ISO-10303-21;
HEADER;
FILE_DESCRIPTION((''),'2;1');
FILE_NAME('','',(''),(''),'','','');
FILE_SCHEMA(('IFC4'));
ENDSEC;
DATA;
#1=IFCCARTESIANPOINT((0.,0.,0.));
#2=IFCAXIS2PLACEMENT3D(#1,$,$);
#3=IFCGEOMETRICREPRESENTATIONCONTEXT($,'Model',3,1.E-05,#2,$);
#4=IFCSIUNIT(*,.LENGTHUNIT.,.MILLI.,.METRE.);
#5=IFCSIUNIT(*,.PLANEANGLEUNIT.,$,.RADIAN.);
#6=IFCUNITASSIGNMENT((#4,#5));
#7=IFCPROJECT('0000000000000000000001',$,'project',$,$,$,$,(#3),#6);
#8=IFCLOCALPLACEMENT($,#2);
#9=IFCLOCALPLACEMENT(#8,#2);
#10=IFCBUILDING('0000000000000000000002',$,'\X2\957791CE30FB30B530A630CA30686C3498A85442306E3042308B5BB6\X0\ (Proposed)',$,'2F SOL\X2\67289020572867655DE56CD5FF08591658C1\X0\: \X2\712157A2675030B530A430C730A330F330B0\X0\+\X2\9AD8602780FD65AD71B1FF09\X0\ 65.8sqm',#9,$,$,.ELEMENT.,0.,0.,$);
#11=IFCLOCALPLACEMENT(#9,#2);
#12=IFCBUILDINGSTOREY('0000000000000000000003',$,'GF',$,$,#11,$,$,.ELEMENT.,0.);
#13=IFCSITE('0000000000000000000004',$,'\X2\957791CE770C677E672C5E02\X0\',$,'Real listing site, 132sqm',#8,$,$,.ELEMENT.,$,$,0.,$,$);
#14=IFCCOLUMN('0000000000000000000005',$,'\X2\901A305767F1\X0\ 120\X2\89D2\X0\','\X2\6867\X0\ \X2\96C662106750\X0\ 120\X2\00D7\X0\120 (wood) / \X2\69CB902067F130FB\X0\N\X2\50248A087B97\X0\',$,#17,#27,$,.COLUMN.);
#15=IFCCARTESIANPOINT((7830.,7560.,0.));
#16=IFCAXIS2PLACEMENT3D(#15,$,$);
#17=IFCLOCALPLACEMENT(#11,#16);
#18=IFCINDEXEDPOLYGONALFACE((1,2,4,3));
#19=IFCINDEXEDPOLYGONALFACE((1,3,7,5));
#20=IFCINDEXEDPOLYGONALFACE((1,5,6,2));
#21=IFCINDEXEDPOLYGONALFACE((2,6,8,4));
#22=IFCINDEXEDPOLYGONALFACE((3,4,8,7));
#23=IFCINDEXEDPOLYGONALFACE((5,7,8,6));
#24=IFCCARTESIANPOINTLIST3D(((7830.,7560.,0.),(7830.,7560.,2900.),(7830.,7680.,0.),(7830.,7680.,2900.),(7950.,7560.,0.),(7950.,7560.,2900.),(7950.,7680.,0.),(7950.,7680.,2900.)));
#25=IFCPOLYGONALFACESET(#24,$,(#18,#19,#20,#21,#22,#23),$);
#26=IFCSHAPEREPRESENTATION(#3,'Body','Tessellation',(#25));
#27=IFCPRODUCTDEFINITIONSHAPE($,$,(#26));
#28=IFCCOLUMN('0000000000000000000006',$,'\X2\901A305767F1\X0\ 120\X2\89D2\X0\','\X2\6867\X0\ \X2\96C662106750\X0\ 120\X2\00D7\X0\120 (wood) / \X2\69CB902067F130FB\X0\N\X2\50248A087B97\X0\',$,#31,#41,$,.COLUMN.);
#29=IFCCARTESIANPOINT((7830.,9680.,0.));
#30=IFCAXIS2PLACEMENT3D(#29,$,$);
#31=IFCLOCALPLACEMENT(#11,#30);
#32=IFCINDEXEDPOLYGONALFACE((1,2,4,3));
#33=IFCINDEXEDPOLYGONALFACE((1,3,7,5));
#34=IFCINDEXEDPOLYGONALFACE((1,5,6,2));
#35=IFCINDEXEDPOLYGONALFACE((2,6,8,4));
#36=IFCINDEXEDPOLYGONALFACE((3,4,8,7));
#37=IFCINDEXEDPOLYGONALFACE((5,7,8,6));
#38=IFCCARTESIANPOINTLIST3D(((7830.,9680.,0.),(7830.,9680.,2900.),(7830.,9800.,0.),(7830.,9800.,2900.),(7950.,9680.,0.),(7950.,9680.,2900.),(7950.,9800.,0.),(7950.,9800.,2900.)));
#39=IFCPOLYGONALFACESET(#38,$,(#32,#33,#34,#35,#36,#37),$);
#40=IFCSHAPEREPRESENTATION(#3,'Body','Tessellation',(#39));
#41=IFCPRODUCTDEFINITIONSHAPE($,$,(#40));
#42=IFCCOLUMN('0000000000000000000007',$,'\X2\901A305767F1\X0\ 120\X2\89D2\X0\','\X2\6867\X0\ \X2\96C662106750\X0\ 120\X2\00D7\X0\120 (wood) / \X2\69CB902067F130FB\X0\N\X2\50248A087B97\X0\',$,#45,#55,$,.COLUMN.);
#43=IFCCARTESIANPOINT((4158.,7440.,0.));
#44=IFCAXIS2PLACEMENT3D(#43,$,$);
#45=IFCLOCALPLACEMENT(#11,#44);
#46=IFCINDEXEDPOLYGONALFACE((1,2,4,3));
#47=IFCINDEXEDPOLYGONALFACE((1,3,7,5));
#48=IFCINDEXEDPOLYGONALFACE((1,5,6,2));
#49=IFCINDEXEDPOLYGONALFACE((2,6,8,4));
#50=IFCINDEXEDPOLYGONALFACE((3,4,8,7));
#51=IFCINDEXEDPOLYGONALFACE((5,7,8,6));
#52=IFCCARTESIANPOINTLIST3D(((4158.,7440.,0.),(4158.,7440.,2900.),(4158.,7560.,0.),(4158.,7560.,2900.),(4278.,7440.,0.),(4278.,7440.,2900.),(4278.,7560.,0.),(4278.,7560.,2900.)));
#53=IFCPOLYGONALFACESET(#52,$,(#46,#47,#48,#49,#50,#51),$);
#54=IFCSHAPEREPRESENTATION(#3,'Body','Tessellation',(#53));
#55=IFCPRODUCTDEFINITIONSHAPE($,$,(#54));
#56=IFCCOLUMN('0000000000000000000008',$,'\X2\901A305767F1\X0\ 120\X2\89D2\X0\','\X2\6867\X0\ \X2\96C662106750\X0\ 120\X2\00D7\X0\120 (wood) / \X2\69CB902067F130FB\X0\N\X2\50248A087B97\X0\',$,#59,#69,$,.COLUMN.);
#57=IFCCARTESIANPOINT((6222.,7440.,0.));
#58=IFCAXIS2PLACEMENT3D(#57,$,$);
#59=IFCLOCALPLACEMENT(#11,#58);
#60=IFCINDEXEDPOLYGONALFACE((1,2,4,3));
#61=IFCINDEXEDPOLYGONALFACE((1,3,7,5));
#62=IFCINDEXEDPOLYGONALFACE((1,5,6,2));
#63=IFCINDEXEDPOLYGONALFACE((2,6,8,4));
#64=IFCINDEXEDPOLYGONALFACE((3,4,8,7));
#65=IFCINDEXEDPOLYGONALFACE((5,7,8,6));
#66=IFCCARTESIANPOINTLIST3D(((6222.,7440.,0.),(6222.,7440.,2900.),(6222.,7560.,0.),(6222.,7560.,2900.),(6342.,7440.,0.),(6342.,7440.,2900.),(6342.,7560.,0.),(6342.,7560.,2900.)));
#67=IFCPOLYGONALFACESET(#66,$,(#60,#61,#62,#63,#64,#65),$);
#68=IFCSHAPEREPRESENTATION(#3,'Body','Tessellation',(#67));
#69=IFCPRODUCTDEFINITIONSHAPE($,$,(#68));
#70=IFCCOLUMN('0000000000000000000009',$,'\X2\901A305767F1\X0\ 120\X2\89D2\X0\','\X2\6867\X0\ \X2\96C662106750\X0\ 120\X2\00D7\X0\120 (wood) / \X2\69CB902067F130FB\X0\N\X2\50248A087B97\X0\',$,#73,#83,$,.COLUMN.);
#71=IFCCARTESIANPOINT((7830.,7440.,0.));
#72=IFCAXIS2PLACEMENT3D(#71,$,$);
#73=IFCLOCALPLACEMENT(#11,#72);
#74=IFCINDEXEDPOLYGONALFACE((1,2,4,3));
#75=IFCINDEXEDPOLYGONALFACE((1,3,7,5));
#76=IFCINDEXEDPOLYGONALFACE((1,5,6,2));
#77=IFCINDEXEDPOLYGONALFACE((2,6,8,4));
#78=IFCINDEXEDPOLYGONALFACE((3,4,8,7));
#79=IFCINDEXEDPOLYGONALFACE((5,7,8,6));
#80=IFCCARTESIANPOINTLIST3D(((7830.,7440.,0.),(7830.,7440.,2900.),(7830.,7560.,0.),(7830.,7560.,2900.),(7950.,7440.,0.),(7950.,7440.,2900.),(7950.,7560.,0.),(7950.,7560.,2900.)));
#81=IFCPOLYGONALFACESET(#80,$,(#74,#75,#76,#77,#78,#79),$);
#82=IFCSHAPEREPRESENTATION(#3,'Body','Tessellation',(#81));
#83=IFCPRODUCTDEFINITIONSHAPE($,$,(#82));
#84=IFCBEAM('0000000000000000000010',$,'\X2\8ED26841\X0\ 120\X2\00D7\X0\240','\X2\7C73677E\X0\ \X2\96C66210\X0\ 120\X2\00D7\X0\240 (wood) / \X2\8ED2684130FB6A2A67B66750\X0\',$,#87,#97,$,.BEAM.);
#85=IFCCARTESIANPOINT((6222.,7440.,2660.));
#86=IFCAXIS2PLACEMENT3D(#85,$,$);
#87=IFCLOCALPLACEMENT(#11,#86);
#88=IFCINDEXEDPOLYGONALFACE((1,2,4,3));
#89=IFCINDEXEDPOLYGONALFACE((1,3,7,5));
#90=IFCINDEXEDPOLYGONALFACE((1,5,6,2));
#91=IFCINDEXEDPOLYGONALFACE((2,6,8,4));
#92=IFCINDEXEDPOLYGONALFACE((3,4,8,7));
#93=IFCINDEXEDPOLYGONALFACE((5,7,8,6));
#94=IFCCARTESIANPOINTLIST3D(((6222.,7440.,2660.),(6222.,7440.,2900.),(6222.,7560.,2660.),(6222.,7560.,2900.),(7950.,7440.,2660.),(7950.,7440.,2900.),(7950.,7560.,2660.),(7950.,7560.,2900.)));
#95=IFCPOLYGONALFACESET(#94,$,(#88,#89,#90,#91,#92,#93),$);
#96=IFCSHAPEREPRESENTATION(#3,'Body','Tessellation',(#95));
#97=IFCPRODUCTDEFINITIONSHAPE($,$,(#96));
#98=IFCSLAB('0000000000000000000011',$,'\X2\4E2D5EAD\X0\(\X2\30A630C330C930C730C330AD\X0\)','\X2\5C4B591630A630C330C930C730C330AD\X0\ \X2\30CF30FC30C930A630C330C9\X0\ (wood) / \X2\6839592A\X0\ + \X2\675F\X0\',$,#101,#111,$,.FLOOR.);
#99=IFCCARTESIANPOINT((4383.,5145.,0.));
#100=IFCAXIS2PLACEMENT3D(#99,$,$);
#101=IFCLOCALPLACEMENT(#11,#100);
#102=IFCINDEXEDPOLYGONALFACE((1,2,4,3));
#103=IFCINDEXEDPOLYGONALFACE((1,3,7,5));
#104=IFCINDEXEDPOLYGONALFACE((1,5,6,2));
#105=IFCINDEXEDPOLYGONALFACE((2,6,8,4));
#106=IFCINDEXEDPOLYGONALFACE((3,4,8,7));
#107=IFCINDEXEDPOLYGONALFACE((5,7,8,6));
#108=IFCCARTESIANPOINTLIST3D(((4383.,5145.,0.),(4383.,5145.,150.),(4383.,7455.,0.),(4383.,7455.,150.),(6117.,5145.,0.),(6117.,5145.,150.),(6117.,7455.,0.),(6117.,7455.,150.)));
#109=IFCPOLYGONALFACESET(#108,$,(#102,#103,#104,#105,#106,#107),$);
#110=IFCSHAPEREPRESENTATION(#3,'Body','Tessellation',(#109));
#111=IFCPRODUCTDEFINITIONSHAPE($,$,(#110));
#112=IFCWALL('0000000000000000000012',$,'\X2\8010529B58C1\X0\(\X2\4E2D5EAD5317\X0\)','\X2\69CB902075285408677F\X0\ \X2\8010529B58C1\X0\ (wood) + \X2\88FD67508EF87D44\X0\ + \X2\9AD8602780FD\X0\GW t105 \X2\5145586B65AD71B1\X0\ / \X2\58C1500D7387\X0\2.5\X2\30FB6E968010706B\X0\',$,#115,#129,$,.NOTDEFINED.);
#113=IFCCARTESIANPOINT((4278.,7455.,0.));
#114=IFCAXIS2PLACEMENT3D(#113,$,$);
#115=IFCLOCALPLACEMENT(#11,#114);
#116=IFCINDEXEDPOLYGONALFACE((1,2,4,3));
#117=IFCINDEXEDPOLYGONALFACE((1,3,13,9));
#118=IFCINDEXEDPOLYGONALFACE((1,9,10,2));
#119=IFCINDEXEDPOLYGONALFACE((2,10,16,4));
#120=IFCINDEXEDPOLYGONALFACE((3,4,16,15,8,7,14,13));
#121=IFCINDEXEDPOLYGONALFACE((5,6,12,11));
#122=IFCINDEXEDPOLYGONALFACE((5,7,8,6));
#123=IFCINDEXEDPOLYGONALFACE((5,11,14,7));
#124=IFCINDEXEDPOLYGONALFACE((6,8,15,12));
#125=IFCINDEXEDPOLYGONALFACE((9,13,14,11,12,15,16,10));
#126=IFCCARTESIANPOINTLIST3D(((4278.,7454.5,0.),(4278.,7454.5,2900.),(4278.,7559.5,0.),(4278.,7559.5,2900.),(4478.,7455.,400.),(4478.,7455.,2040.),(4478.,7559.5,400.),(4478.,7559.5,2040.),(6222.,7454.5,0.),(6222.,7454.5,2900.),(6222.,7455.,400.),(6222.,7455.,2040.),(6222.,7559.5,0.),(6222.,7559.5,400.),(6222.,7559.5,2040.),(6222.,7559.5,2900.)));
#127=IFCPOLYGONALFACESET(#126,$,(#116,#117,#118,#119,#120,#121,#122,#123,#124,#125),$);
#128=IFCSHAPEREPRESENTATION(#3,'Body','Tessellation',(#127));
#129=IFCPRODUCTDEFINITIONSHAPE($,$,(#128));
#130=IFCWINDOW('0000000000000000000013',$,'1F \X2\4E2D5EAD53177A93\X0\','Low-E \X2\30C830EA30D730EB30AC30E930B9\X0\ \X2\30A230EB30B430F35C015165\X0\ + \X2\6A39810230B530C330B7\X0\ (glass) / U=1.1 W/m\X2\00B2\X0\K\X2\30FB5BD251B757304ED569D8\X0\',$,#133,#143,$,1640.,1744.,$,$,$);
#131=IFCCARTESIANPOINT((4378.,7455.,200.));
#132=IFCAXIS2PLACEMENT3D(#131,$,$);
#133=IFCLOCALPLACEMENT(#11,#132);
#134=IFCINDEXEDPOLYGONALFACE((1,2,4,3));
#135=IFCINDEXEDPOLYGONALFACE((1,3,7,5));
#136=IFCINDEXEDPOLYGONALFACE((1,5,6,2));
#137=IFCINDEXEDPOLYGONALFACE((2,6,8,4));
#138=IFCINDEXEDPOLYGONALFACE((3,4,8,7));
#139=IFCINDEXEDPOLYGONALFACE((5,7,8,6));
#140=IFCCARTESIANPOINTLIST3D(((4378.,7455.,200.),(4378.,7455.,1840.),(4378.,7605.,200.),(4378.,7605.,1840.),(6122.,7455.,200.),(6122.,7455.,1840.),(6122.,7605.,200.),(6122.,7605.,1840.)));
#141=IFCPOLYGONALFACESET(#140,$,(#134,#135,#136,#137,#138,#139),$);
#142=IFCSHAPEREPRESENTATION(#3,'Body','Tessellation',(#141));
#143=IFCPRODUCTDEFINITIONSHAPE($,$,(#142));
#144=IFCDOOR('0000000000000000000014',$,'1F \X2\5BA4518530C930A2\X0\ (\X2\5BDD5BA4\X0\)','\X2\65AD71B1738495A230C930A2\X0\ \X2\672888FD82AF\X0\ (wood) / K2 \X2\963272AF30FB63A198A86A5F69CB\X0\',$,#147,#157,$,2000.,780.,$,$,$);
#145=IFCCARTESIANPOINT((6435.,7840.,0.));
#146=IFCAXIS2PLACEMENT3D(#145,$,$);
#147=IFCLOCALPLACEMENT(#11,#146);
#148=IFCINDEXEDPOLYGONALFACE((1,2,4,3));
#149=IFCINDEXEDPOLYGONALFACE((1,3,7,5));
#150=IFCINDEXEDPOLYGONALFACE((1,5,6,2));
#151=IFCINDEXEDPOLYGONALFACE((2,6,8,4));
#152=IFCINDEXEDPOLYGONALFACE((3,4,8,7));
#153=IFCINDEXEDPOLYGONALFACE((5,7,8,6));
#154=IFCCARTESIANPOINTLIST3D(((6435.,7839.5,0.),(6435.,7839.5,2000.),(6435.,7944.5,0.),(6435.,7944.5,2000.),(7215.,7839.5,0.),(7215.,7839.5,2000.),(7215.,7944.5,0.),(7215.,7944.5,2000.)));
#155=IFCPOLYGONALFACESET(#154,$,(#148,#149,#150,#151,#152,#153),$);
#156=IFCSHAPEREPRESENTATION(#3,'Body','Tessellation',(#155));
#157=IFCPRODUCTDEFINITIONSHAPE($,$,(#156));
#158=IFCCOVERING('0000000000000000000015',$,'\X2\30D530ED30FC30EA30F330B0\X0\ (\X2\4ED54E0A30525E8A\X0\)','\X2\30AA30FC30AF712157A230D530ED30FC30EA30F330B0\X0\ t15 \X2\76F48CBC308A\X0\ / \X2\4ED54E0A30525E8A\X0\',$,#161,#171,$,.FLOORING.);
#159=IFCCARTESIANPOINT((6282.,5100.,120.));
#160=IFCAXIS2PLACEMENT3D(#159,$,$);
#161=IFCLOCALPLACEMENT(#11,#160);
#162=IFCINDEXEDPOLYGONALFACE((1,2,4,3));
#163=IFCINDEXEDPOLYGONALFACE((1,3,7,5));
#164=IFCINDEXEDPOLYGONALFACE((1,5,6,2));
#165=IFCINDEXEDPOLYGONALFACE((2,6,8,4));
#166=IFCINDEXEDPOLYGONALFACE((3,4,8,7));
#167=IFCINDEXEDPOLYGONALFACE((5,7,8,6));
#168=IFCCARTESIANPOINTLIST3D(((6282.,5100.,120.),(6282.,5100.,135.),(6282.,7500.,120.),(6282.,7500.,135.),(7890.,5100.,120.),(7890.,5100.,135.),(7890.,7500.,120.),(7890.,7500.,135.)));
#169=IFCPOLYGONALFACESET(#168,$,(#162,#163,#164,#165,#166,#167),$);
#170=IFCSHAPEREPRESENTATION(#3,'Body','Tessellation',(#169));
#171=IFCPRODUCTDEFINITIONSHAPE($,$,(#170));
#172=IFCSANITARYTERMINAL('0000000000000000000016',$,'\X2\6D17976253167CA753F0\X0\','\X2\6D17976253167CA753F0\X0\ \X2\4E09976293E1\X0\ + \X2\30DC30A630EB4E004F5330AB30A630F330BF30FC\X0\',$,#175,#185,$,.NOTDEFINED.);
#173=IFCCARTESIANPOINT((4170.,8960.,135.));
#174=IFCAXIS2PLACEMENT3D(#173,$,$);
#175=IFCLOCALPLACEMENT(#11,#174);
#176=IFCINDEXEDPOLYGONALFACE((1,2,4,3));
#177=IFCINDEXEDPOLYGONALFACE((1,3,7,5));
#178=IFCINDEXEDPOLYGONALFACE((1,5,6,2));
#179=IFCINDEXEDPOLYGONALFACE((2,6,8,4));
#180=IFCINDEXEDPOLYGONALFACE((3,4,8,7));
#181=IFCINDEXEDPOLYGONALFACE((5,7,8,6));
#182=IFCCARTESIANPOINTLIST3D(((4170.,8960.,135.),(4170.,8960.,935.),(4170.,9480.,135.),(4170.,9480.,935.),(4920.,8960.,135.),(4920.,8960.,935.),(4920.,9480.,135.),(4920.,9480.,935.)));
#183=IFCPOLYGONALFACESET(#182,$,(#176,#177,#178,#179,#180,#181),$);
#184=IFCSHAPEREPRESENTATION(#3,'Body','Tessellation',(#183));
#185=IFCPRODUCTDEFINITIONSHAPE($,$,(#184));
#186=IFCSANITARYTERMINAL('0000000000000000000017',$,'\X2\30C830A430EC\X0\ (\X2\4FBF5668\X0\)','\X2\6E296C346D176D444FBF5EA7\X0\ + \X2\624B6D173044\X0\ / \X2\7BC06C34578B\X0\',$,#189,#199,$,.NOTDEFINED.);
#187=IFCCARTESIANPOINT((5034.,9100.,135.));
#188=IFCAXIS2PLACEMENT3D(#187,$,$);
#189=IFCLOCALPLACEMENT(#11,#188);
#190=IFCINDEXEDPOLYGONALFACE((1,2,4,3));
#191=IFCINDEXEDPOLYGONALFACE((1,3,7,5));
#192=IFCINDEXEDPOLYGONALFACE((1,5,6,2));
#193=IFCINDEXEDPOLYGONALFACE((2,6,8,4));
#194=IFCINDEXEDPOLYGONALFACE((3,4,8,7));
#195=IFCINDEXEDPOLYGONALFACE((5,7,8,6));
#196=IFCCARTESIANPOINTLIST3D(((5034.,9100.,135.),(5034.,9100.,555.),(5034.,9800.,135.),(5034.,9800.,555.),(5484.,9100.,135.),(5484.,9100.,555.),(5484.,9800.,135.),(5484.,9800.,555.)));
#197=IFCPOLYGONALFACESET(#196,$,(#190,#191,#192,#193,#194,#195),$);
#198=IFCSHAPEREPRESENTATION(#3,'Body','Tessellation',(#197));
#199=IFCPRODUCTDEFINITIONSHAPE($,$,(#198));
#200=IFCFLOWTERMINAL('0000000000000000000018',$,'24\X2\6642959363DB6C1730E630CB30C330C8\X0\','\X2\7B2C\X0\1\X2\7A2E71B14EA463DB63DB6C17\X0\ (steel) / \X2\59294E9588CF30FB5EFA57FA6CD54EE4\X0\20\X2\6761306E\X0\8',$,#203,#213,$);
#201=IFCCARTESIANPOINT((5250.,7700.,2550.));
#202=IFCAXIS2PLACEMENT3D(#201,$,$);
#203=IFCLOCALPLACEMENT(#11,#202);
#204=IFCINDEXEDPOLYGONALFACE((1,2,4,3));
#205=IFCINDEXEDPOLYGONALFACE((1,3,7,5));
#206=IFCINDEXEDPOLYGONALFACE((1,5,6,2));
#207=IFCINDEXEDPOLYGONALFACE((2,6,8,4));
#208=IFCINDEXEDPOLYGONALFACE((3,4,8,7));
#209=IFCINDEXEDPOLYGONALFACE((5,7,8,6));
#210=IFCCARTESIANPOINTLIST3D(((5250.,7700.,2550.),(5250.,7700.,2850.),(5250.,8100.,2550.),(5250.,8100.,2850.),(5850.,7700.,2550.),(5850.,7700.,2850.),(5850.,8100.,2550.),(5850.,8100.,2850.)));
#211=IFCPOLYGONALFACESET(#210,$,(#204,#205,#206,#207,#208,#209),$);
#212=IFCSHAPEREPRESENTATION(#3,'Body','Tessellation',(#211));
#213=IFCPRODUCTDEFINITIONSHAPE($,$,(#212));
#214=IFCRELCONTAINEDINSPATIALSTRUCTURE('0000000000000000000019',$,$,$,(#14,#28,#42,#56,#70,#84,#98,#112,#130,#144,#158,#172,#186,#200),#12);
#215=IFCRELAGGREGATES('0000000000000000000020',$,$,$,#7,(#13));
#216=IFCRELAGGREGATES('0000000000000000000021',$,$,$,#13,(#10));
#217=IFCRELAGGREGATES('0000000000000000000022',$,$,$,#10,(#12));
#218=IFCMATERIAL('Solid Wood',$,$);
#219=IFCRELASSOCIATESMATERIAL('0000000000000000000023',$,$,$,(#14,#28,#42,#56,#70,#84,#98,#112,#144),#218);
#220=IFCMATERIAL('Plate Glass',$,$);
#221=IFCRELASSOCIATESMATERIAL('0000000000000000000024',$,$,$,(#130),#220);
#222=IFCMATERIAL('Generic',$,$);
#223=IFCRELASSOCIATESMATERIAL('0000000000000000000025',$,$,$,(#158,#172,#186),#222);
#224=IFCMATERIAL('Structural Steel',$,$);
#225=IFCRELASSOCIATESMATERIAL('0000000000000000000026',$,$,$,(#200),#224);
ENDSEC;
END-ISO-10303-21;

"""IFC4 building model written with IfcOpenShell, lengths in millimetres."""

from ifc_helpers import new_model, si_unit, frame, frame_2d, origin, place, context, project, spatial, rectangle, extrude, material, element, fill, save


model = new_model("IFC4")

# Units and contexts
model_context = context("Model", 3, precision=1e-05, world=origin())
ifc_project = project(units=[si_unit("LENGTHUNIT", "METRE", prefix="MILLI"), si_unit("PLANEANGLEUNIT", "RADIAN")], contexts=[model_context])

# Site, building, storey
site_placement = place(None, origin())
site = spatial("IfcSite", under=ifc_project, at=site_placement, Name="長野県松本市", ObjectType="Real listing site, 132sqm", CompositionType="ELEMENT", RefElevation=0.0)
building_placement = place(site_placement, origin())
building = spatial("IfcBuilding", under=site, at=building_placement, Name="長野・サウナと水風呂のある家 (Proposed)", ObjectType="2F SOL木造在来工法（外壁: 無垢材サイディング+高性能断熱） 65.8sqm", CompositionType="ELEMENT", ElevationOfRefHeight=0.0, ElevationOfTerrain=0.0)
storey_placement = place(building_placement, origin())
storey = spatial("IfcBuildingStorey", under=building, at=storey_placement, Name="GF", CompositionType="ELEMENT", Elevation=0.0)

# Columns
ifc_material_1 = material(Name="Solid Wood")
column_1_placement = place(storey_placement, frame((7830.0, 7560.0, 0.0)))
element("IfcColumn", 1, at=column_1_placement, inside=storey, material=ifc_material_1, Name="通し柱 120角", Description="桧 集成材 120×120 (wood) / 構造柱・N値計算", PredefinedType="COLUMN", context=model_context, shape_type="SweptSolid", body=[
    extrude(rectangle(XDim=120.0, YDim=120.0, at=frame_2d((60.0, 60.0))), frame((7830.0, 7560.0, 0.0)), (0.0, 0.0, 1.0), 2900.0),
])
column_2_placement = place(storey_placement, frame((7830.0, 9680.0, 0.0)))
element("IfcColumn", 2, at=column_2_placement, inside=storey, material=ifc_material_1, Name="通し柱 120角", Description="桧 集成材 120×120 (wood) / 構造柱・N値計算", PredefinedType="COLUMN", context=model_context, shape_type="SweptSolid", body=[
    extrude(rectangle(XDim=120.0, YDim=120.0, at=frame_2d((60.0, 60.0))), frame((7830.0, 9680.0, 0.0)), (0.0, 0.0, 1.0), 2900.0),
])
column_3_placement = place(storey_placement, frame((4158.0, 7440.0, 0.0)))
element("IfcColumn", 3, at=column_3_placement, inside=storey, material=ifc_material_1, Name="通し柱 120角", Description="桧 集成材 120×120 (wood) / 構造柱・N値計算", PredefinedType="COLUMN", context=model_context, shape_type="SweptSolid", body=[
    extrude(rectangle(XDim=120.0, YDim=120.0, at=frame_2d((60.0, 60.0))), frame((4158.0, 7440.0, 0.0)), (0.0, 0.0, 1.0), 2900.0),
])
column_4_placement = place(storey_placement, frame((6222.0, 7440.0, 0.0)))
element("IfcColumn", 4, at=column_4_placement, inside=storey, material=ifc_material_1, Name="通し柱 120角", Description="桧 集成材 120×120 (wood) / 構造柱・N値計算", PredefinedType="COLUMN", context=model_context, shape_type="SweptSolid", body=[
    extrude(rectangle(XDim=120.0, YDim=120.0, at=frame_2d((60.0, 60.0))), frame((6222.0, 7440.0, 0.0)), (0.0, 0.0, 1.0), 2900.0),
])
column_5_placement = place(storey_placement, frame((7830.0, 7440.0, 0.0)))
element("IfcColumn", 5, at=column_5_placement, inside=storey, material=ifc_material_1, Name="通し柱 120角", Description="桧 集成材 120×120 (wood) / 構造柱・N値計算", PredefinedType="COLUMN", context=model_context, shape_type="SweptSolid", body=[
    extrude(rectangle(XDim=120.0, YDim=120.0, at=frame_2d((60.0, 60.0))), frame((7830.0, 7440.0, 0.0)), (0.0, 0.0, 1.0), 2900.0),
])

# Beam
beam_1_placement = place(storey_placement, frame((6222.0, 7440.0, 2660.0)))
element("IfcBeam", 6, at=beam_1_placement, inside=storey, material=ifc_material_1, Name="軒桁 120×240", Description="米松 集成 120×240 (wood) / 軒桁・横架材", PredefinedType="BEAM", context=model_context, shape_type="SweptSolid", body=[
    extrude(rectangle(XDim=1728.0, YDim=120.0, at=frame_2d((864.0, 60.0))), frame((6222.0, 7440.0, 2660.0)), (0.0, 0.0, 1.0), 240.0),
])

# Slab
slab_placement = place(storey_placement, frame((4383.0, 5145.0, 0.0)))
element("IfcSlab", 7, at=slab_placement, inside=storey, material=ifc_material_1, Name="中庭(ウッドデッキ)", Description="屋外ウッドデッキ ハードウッド (wood) / 根太 + 束", PredefinedType="FLOOR", context=model_context, shape_type="SweptSolid", body=[
    extrude(rectangle(XDim=1734.0, YDim=2310.0, at=frame_2d((867.0, 1155.0))), frame((4383.0, 5145.0, 0.0)), (0.0, 0.0, 1.0), 150.0),
])

# Wall, opening, window
wall_1_placement = place(storey_placement, frame((4278.0, 7455.0, 0.0)))
wall_1 = element("IfcWall", 8, at=wall_1_placement, inside=storey, material=ifc_material_1, Name="耐力壁(中庭北)", Description="構造用合板 耐力壁 (wood) + 製材軸組 + 高性能GW t105 充填断熱 / 壁倍率2.5・準耐火", PredefinedType="NOTDEFINED", context=model_context, shape_type="SweptSolid", body=[
    extrude(rectangle(XDim=1944.0, YDim=105.0, at=frame_2d((972.0, 52.0))), frame((4278.0, 7455.0, 0.0)), (0.0, 0.0, 1.0), 2900.0),
])
opening_placement = place(storey_placement, frame((4378.0, 7455.0, 200.0)))
opening = element("IfcOpeningElement", 9, at=opening_placement, cuts=wall_1, PredefinedType="NOTDEFINED", context=model_context, shape_type="SweptSolid", body=[
    extrude(rectangle(XDim=1744.0, YDim=150.0, at=frame_2d((872.0, 75.0))), frame((4378.0, 7455.0, 200.0)), (0.0, 0.0, 1.0), 1640.0),
])
ifc_material_2 = material(Name="Plate Glass")
window_placement = place(storey_placement, frame((4378.0, 7455.0, 200.0)))
window = element("IfcWindow", 10, at=window_placement, inside=storey, material=ifc_material_2, Name="1F 中庭北窓", Description="Low-E トリプルガラス アルゴン封入 + 樹脂サッシ (glass) / U=1.1 W/m²K・寒冷地仕様", OverallHeight=1640.0, OverallWidth=1744.0, context=model_context, shape_type="SweptSolid", body=[
    extrude(rectangle(XDim=1744.0, YDim=150.0, at=frame_2d((872.0, 75.0))), frame((4378.0, 7455.0, 200.0)), (0.0, 0.0, 1.0), 1640.0),
])
fill(opening, window)

# Door
door_placement = place(storey_placement, frame((6435.0, 7840.0, 0.0)))
element("IfcDoor", 11, at=door_placement, inside=storey, material=ifc_material_1, Name="1F 室内ドア (寝室)", Description="断熱玄関ドア 木製芯 (wood) / K2 防犯・採風機構", OverallHeight=2000.0, OverallWidth=780.0, context=model_context, shape_type="SweptSolid", body=[
    extrude(rectangle(XDim=780.0, YDim=105.0, at=frame_2d((390.0, 52.0))), frame((6435.0, 7840.0, 0.0)), (0.0, 0.0, 1.0), 2000.0),
])

# Covering
ifc_material_3 = material(Name="Generic")
covering_placement = place(storey_placement, frame((6282.0, 5100.0, 120.0)))
element("IfcCovering", 12, at=covering_placement, inside=storey, material=ifc_material_3, Name="フローリング (仕上げ床)", Description="オーク無垢フローリング t15 直貼り / 仕上げ床", PredefinedType="FLOORING", context=model_context, shape_type="SweptSolid", body=[
    extrude(rectangle(XDim=1608.0, YDim=2400.0, at=frame_2d((804.0, 1200.0))), frame((6282.0, 5100.0, 120.0)), (0.0, 0.0, 1.0), 15.0),
])

# Sanitary terminals
sanitary_terminal_1_placement = place(storey_placement, frame((4170.0, 8960.0, 135.0)))
element("IfcSanitaryTerminal", 13, at=sanitary_terminal_1_placement, inside=storey, material=ifc_material_3, Name="洗面化粧台", Description="洗面化粧台 三面鏡 + ボウル一体カウンター", PredefinedType="NOTDEFINED", context=model_context, shape_type="SweptSolid", body=[
    extrude(rectangle(XDim=750.0, YDim=520.0, at=frame_2d((375.0, 260.0))), frame((4170.0, 8960.0, 135.0)), (0.0, 0.0, 1.0), 800.0),
])
sanitary_terminal_2_placement = place(storey_placement, frame((5034.0, 9100.0, 135.0)))
element("IfcSanitaryTerminal", 14, at=sanitary_terminal_2_placement, inside=storey, material=ifc_material_3, Name="トイレ (便器)", Description="温水洗浄便座 + 手洗い / 節水型", PredefinedType="NOTDEFINED", context=model_context, shape_type="SweptSolid", body=[
    extrude(rectangle(XDim=450.0, YDim=700.0, at=frame_2d((225.0, 350.0))), frame((5034.0, 9100.0, 135.0)), (0.0, 0.0, 1.0), 420.0),
])

# Flow terminal
ifc_material_4 = material(Name="Structural Steel")
flow_terminal_placement = place(storey_placement, frame((5250.0, 7700.0, 2550.0)))
element("IfcFlowTerminal", 15, at=flow_terminal_placement, inside=storey, material=ifc_material_4, Name="24時間換気ユニット", Description="第1種熱交換換気 (steel) / 天井裏・建基法令20条の8", context=model_context, shape_type="SweptSolid", body=[
    extrude(rectangle(XDim=600.0, YDim=400.0, at=frame_2d((300.0, 200.0))), frame((5250.0, 7700.0, 2550.0)), (0.0, 0.0, 1.0), 300.0),
])

save(model, "model.ifc")
